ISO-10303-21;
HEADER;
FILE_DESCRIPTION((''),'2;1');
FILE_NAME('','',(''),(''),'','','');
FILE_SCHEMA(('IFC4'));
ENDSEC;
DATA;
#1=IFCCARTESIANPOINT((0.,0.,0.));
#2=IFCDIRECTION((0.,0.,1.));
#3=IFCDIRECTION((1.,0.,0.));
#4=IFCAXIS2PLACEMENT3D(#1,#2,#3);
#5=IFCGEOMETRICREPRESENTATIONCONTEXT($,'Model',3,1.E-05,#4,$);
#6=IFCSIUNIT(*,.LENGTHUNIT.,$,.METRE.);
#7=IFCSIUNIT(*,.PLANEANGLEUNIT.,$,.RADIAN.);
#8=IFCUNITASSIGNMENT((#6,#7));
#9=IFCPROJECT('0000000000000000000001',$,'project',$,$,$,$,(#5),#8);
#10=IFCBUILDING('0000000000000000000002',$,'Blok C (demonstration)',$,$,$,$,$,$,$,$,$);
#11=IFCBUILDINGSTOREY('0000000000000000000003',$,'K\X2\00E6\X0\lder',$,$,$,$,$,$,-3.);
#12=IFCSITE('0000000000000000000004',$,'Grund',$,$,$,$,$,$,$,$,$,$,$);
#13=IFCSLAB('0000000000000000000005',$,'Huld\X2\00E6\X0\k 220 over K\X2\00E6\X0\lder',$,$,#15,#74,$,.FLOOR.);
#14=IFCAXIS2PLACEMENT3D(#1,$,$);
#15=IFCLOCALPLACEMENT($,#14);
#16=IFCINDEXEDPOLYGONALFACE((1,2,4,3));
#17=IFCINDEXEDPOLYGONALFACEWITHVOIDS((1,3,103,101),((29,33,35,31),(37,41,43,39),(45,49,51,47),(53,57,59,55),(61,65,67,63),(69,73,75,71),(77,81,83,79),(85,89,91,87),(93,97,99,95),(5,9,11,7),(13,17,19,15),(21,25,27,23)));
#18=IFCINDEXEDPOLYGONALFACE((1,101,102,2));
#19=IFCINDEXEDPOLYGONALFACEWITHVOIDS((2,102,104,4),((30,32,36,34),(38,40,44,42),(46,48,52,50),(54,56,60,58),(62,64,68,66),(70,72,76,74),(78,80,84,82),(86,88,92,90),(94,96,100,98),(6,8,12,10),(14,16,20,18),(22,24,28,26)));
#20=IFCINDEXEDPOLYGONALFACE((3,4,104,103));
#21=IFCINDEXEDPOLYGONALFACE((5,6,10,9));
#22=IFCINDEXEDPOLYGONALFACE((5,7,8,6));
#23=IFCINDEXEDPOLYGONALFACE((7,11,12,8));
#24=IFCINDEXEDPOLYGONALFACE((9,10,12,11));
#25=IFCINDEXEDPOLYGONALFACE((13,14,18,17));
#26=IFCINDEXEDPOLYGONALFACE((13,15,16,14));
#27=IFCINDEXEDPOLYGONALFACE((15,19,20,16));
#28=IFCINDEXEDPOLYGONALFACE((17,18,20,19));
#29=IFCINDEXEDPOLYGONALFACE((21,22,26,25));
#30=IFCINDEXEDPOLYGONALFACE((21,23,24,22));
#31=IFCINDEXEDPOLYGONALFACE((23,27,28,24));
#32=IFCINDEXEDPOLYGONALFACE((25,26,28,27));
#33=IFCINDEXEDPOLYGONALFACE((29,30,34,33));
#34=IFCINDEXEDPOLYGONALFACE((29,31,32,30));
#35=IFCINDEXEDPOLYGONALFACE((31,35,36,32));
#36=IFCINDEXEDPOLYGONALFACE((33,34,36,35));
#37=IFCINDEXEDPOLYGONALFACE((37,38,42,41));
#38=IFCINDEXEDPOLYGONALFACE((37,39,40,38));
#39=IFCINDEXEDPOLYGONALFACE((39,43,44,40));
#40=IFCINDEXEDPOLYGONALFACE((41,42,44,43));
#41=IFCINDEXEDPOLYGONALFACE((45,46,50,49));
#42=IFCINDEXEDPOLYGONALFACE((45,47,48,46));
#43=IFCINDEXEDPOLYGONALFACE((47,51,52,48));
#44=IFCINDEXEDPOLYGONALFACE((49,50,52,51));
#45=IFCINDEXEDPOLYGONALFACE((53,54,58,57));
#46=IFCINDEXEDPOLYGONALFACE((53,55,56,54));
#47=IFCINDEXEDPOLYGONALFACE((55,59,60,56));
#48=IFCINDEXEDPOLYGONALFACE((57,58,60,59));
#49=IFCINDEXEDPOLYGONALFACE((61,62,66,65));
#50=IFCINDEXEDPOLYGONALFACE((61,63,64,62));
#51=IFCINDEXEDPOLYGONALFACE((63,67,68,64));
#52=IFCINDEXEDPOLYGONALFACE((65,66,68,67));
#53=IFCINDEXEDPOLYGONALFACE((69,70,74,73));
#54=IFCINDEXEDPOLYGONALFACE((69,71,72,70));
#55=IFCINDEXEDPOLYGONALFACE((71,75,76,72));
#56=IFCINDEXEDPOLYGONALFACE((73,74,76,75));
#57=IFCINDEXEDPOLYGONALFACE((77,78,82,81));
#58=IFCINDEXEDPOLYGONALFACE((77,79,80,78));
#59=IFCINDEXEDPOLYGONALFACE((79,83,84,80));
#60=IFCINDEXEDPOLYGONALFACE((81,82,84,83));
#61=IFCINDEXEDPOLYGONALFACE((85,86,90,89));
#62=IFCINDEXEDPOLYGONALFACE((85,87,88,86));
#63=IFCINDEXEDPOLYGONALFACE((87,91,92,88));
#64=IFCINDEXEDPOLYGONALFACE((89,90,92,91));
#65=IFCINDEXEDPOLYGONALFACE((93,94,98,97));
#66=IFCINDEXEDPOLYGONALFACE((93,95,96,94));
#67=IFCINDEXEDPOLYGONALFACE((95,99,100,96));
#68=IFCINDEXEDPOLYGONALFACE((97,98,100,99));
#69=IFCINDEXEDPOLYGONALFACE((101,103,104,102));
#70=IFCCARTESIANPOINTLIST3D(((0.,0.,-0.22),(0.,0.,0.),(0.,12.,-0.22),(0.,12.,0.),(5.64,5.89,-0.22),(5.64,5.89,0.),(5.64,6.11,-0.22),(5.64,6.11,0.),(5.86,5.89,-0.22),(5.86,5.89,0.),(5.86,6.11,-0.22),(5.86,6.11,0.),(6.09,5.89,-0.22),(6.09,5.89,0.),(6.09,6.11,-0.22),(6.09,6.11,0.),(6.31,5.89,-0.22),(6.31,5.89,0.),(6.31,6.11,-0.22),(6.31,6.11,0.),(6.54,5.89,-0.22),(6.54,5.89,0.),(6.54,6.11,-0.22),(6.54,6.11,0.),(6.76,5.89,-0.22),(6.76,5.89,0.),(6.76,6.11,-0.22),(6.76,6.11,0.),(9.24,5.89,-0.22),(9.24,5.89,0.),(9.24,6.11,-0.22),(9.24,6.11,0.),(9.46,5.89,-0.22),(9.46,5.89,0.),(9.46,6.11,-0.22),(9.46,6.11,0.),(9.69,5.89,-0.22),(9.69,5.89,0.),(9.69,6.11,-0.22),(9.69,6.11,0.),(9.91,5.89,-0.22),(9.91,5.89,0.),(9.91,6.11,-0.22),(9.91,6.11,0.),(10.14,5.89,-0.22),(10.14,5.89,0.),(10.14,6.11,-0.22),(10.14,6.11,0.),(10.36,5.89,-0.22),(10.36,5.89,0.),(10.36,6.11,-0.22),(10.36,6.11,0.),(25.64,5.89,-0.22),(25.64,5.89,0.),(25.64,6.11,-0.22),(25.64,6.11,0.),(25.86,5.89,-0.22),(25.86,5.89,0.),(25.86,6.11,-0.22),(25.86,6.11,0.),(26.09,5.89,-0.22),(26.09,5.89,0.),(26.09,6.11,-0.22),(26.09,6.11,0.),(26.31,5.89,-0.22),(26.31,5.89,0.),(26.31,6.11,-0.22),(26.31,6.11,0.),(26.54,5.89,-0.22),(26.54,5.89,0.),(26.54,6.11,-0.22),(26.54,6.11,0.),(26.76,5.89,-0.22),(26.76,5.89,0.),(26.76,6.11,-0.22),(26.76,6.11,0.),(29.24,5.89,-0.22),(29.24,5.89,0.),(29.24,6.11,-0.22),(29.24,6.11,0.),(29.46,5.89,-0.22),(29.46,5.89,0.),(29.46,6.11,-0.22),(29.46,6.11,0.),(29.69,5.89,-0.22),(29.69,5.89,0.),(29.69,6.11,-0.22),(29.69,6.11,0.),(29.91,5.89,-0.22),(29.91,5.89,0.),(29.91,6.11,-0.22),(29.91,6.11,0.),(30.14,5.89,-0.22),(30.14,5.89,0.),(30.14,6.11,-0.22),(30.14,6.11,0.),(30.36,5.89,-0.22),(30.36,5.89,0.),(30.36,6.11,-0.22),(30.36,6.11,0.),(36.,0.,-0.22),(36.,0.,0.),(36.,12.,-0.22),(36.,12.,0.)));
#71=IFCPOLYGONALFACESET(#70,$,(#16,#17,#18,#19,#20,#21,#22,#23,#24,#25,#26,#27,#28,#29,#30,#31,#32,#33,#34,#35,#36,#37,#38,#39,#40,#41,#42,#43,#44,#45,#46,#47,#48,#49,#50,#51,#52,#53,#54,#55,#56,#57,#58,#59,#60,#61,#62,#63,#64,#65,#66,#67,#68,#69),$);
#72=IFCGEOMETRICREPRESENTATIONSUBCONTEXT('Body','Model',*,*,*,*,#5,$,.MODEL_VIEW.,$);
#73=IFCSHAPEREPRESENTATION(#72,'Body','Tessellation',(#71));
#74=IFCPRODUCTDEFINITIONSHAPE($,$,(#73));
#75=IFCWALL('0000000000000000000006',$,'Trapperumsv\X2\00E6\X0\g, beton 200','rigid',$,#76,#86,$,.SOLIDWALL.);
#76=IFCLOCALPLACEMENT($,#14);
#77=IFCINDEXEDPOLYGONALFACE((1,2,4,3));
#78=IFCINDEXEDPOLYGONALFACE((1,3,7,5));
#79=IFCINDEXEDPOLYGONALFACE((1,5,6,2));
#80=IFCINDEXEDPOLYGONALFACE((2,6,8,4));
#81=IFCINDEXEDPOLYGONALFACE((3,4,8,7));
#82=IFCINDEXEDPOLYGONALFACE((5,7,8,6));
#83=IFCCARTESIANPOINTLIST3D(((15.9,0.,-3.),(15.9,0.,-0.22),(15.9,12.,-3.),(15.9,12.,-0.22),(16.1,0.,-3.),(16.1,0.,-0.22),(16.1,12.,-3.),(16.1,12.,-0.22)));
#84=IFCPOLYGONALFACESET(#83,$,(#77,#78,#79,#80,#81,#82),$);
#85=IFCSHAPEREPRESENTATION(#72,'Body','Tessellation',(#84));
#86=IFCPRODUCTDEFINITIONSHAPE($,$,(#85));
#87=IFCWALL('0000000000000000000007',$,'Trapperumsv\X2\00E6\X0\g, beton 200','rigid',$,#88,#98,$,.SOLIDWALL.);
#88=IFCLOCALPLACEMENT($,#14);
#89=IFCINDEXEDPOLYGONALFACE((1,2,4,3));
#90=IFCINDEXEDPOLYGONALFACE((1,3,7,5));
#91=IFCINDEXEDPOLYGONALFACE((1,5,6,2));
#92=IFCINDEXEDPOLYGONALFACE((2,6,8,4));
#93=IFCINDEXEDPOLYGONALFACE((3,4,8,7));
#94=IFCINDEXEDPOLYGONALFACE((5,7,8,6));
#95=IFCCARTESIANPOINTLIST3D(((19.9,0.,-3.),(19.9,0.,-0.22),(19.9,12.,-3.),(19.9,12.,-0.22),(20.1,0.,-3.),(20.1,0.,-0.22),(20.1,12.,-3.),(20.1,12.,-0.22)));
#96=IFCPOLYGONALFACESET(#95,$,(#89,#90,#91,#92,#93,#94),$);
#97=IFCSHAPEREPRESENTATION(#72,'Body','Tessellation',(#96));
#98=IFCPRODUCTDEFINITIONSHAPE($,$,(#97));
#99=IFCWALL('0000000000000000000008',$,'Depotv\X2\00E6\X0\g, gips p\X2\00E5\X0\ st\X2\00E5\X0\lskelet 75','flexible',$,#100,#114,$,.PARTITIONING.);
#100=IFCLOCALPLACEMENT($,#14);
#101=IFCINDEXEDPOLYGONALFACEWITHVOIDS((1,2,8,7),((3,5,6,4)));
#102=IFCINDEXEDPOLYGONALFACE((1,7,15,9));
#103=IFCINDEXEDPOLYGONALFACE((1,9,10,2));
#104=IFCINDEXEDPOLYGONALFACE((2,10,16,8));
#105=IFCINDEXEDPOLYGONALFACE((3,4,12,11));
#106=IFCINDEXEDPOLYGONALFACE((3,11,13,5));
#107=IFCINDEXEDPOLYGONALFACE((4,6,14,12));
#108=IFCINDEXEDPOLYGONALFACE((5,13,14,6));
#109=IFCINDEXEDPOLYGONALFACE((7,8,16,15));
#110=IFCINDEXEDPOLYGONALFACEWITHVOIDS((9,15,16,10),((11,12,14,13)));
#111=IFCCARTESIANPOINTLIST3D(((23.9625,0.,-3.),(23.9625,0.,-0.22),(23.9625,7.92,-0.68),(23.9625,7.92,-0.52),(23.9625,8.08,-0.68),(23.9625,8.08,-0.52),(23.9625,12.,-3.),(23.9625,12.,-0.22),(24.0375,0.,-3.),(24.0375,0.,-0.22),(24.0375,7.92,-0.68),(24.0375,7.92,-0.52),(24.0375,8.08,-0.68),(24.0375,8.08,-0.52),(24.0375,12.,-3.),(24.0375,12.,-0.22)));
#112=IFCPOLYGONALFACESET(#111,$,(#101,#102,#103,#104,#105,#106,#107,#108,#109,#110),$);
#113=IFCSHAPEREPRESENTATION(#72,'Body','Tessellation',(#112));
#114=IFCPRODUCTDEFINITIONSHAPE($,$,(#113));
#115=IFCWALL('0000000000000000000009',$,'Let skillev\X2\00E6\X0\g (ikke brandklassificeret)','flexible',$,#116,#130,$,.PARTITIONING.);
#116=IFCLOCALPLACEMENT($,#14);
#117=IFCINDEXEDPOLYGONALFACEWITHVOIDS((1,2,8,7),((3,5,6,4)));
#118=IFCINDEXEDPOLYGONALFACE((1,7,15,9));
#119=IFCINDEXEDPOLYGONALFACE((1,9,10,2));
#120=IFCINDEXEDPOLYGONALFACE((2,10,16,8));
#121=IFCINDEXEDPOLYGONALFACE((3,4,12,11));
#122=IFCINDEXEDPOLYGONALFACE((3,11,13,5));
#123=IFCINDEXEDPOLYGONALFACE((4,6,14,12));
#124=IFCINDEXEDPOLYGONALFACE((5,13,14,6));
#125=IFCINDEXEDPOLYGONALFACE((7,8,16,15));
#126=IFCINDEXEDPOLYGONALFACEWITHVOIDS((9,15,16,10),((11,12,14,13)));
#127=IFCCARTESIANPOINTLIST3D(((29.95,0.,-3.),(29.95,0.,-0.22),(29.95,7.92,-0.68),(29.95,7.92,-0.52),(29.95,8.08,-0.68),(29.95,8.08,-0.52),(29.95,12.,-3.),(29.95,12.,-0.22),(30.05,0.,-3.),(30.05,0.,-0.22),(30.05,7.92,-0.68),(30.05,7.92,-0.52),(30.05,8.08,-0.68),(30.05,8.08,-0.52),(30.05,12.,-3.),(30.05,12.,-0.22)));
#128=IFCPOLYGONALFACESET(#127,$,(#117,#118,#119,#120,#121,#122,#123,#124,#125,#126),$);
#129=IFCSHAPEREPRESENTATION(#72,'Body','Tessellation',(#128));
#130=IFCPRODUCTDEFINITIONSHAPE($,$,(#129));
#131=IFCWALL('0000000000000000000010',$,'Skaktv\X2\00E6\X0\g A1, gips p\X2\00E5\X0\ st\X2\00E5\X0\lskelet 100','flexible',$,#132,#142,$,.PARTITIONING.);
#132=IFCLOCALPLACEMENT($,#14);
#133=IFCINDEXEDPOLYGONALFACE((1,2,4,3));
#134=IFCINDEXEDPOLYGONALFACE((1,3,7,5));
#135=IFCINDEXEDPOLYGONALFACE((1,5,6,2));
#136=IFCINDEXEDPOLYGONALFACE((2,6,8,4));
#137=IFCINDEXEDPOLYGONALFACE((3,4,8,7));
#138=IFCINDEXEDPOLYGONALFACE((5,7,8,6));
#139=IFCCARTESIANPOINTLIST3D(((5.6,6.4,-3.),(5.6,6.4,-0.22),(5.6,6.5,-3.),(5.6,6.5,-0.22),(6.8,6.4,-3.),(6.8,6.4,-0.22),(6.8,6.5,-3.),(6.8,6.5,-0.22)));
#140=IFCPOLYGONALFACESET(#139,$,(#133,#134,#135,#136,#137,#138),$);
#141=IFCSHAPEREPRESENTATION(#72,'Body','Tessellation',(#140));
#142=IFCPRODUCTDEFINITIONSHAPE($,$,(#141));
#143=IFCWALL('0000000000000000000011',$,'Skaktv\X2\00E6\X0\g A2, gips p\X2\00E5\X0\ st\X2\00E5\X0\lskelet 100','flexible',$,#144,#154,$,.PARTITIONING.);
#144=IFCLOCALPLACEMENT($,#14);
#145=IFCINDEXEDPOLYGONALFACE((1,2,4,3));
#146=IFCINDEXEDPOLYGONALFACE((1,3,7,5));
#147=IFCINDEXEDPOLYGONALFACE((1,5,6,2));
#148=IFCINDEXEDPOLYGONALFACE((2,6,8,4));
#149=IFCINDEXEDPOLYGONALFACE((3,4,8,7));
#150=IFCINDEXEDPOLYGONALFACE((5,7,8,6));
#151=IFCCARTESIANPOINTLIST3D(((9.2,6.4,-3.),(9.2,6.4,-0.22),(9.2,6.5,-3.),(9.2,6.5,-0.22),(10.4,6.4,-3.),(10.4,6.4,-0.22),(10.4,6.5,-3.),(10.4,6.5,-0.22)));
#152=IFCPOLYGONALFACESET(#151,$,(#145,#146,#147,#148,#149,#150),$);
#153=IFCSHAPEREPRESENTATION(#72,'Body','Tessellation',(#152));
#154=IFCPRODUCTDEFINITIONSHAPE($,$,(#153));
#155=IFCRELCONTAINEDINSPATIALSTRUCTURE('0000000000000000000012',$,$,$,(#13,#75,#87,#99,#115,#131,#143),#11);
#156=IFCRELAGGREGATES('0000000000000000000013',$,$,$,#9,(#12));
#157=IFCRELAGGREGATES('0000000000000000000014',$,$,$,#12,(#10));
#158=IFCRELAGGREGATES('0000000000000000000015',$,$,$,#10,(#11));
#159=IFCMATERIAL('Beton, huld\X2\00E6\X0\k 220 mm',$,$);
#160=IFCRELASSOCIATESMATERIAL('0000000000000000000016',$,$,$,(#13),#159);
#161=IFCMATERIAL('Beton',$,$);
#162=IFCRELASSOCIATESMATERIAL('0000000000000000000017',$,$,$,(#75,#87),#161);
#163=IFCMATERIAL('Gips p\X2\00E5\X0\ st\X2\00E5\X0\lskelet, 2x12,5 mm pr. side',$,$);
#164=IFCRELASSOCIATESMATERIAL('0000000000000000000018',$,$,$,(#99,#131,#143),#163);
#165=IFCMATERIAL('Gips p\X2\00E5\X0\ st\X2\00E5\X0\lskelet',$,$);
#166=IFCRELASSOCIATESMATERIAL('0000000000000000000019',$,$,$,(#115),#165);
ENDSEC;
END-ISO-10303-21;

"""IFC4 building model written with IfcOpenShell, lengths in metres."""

from ifc_helpers import new_model, si_unit, frame, origin_with_axes, place, context, subcontext, project, spatial, polyline, outline, extrude, material, element, save


model = new_model("IFC4")

# Units and contexts
model_context = context("Model", 3, precision=1e-05, world=origin_with_axes())
body_context = subcontext(model_context, "Body", "Model", "MODEL_VIEW")
ifc_project = project(units=[si_unit("LENGTHUNIT", "METRE"), si_unit("PLANEANGLEUNIT", "RADIAN")], contexts=[model_context])

# Site, building, storey
site = spatial("IfcSite", under=ifc_project, Name="Grund")
building = spatial("IfcBuilding", under=site, Name="Blok C (demonstration)")
storey = spatial("IfcBuildingStorey", under=building, Name="Kælder", Elevation=-3.0)

# Slab, openings
ifc_material_1 = material(Name="Beton, huldæk 220 mm")
slab_placement = place(None, origin_with_axes())
slab = element("IfcSlab", 1, at=slab_placement, inside=storey, material=ifc_material_1, Name="Huldæk 220 over Kælder", PredefinedType="FLOOR", context=body_context, shape_type="SweptSolid", body=[
    extrude(outline(polyline([(0.0, 0.0), (36.0, 0.0), (36.0, 12.0), (0.0, 12.0), (0.0, 0.0)])), frame((0.0, 0.0, -0.22)), (0.0, 0.0, 1.0), 0.22),
])
opening_1_placement = place(slab_placement, origin_with_axes())
element("IfcOpeningElement", 2, at=opening_1_placement, cuts=slab, PredefinedType="OPENING", context=body_context, shape_type="SweptSolid", body=[
    extrude(outline(polyline([(5.64, 5.89), (5.86, 5.89), (5.86, 6.11), (5.64, 6.11), (5.64, 5.89)])), frame((0.0, 0.0, -0.23)), (0.0, 0.0, 1.0), 0.24),
])
opening_2_placement = place(slab_placement, origin_with_axes())
element("IfcOpeningElement", 3, at=opening_2_placement, cuts=slab, PredefinedType="OPENING", context=body_context, shape_type="SweptSolid", body=[
    extrude(outline(polyline([(6.09, 5.89), (6.31, 5.89), (6.31, 6.11), (6.09, 6.11), (6.09, 5.89)])), frame((0.0, 0.0, -0.23)), (0.0, 0.0, 1.0), 0.24),
])
opening_3_placement = place(slab_placement, origin_with_axes())
element("IfcOpeningElement", 4, at=opening_3_placement, cuts=slab, PredefinedType="OPENING", context=body_context, shape_type="SweptSolid", body=[
    extrude(outline(polyline([(6.54, 5.89), (6.76, 5.89), (6.76, 6.11), (6.54, 6.11), (6.54, 5.89)])), frame((0.0, 0.0, -0.23)), (0.0, 0.0, 1.0), 0.24),
])
opening_4_placement = place(slab_placement, origin_with_axes())
element("IfcOpeningElement", 5, at=opening_4_placement, cuts=slab, PredefinedType="OPENING", context=body_context, shape_type="SweptSolid", body=[
    extrude(outline(polyline([(9.24, 5.89), (9.46, 5.89), (9.46, 6.11), (9.24, 6.11), (9.24, 5.89)])), frame((0.0, 0.0, -0.23)), (0.0, 0.0, 1.0), 0.24),
])
opening_5_placement = place(slab_placement, origin_with_axes())
element("IfcOpeningElement", 6, at=opening_5_placement, cuts=slab, PredefinedType="OPENING", context=body_context, shape_type="SweptSolid", body=[
    extrude(outline(polyline([(9.69, 5.89), (9.91, 5.89), (9.91, 6.11), (9.69, 6.11), (9.69, 5.89)])), frame((0.0, 0.0, -0.23)), (0.0, 0.0, 1.0), 0.24),
])
opening_6_placement = place(slab_placement, origin_with_axes())
element("IfcOpeningElement", 7, at=opening_6_placement, cuts=slab, PredefinedType="OPENING", context=body_context, shape_type="SweptSolid", body=[
    extrude(outline(polyline([(10.14, 5.89), (10.36, 5.89), (10.36, 6.11), (10.14, 6.11), (10.14, 5.89)])), frame((0.0, 0.0, -0.23)), (0.0, 0.0, 1.0), 0.24),
])
opening_7_placement = place(slab_placement, origin_with_axes())
element("IfcOpeningElement", 8, at=opening_7_placement, cuts=slab, PredefinedType="OPENING", context=body_context, shape_type="SweptSolid", body=[
    extrude(outline(polyline([(25.64, 5.89), (25.86, 5.89), (25.86, 6.11), (25.64, 6.11), (25.64, 5.89)])), frame((0.0, 0.0, -0.23)), (0.0, 0.0, 1.0), 0.24),
])
opening_8_placement = place(slab_placement, origin_with_axes())
element("IfcOpeningElement", 9, at=opening_8_placement, cuts=slab, PredefinedType="OPENING", context=body_context, shape_type="SweptSolid", body=[
    extrude(outline(polyline([(26.09, 5.89), (26.31, 5.89), (26.31, 6.11), (26.09, 6.11), (26.09, 5.89)])), frame((0.0, 0.0, -0.23)), (0.0, 0.0, 1.0), 0.24),
])
opening_9_placement = place(slab_placement, origin_with_axes())
element("IfcOpeningElement", 10, at=opening_9_placement, cuts=slab, PredefinedType="OPENING", context=body_context, shape_type="SweptSolid", body=[
    extrude(outline(polyline([(26.54, 5.89), (26.76, 5.89), (26.76, 6.11), (26.54, 6.11), (26.54, 5.89)])), frame((0.0, 0.0, -0.23)), (0.0, 0.0, 1.0), 0.24),
])
opening_10_placement = place(slab_placement, origin_with_axes())
element("IfcOpeningElement", 11, at=opening_10_placement, cuts=slab, PredefinedType="OPENING", context=body_context, shape_type="SweptSolid", body=[
    extrude(outline(polyline([(29.24, 5.89), (29.46, 5.89), (29.46, 6.11), (29.24, 6.11), (29.24, 5.89)])), frame((0.0, 0.0, -0.23)), (0.0, 0.0, 1.0), 0.24),
])
opening_11_placement = place(slab_placement, origin_with_axes())
element("IfcOpeningElement", 12, at=opening_11_placement, cuts=slab, PredefinedType="OPENING", context=body_context, shape_type="SweptSolid", body=[
    extrude(outline(polyline([(29.69, 5.89), (29.91, 5.89), (29.91, 6.11), (29.69, 6.11), (29.69, 5.89)])), frame((0.0, 0.0, -0.23)), (0.0, 0.0, 1.0), 0.24),
])
opening_12_placement = place(slab_placement, origin_with_axes())
element("IfcOpeningElement", 13, at=opening_12_placement, cuts=slab, PredefinedType="OPENING", context=body_context, shape_type="SweptSolid", body=[
    extrude(outline(polyline([(30.14, 5.89), (30.36, 5.89), (30.36, 6.11), (30.14, 6.11), (30.14, 5.89)])), frame((0.0, 0.0, -0.23)), (0.0, 0.0, 1.0), 0.24),
])

# Walls
ifc_material_2 = material(Name="Beton")
wall_1_placement = place(None, origin_with_axes())
element("IfcWall", 14, at=wall_1_placement, inside=storey, material=ifc_material_2, Name="Trapperumsvæg, beton 200", Description="rigid", PredefinedType="SOLIDWALL", context=body_context, shape_type="SweptSolid", body=[
    extrude(outline(polyline([(15.9, 0.0), (16.1, 0.0), (16.1, 12.0), (15.9, 12.0), (15.9, 0.0)])), frame((0.0, 0.0, -3.0)), (0.0, 0.0, 1.0), 2.78),
])
wall_2_placement = place(None, origin_with_axes())
element("IfcWall", 15, at=wall_2_placement, inside=storey, material=ifc_material_2, Name="Trapperumsvæg, beton 200", Description="rigid", PredefinedType="SOLIDWALL", context=body_context, shape_type="SweptSolid", body=[
    extrude(outline(polyline([(19.9, 0.0), (20.1, 0.0), (20.1, 12.0), (19.9, 12.0), (19.9, 0.0)])), frame((0.0, 0.0, -3.0)), (0.0, 0.0, 1.0), 2.78),
])

# Walls, openings
ifc_material_3 = material(Name="Gips på stålskelet, 2x12,5 mm pr. side")
wall_3_placement = place(None, origin_with_axes())
wall_3 = element("IfcWall", 16, at=wall_3_placement, inside=storey, material=ifc_material_3, Name="Depotvæg, gips på stålskelet 75", Description="flexible", PredefinedType="PARTITIONING", context=body_context, shape_type="SweptSolid", body=[
    extrude(outline(polyline([(23.9625, 0.0), (24.0375, 0.0), (24.0375, 12.0), (23.9625, 12.0), (23.9625, 0.0)])), frame((0.0, 0.0, -3.0)), (0.0, 0.0, 1.0), 2.78),
])
opening_13_placement = place(wall_3_placement, origin_with_axes())
element("IfcOpeningElement", 17, at=opening_13_placement, cuts=wall_3, PredefinedType="OPENING", context=body_context, shape_type="SweptSolid", body=[
    extrude(outline(polyline([(23.88, 7.92), (24.12, 7.92), (24.12, 8.08), (23.88, 8.08), (23.88, 7.92)])), frame((0.0, 0.0, -0.68)), (0.0, 0.0, 1.0), 0.16),
])
ifc_material_4 = material(Name="Gips på stålskelet")
wall_4_placement = place(None, origin_with_axes())
wall_4 = element("IfcWall", 18, at=wall_4_placement, inside=storey, material=ifc_material_4, Name="Let skillevæg (ikke brandklassificeret)", Description="flexible", PredefinedType="PARTITIONING", context=body_context, shape_type="SweptSolid", body=[
    extrude(outline(polyline([(29.95, 0.0), (30.05, 0.0), (30.05, 12.0), (29.95, 12.0), (29.95, 0.0)])), frame((0.0, 0.0, -3.0)), (0.0, 0.0, 1.0), 2.78),
])
opening_14_placement = place(wall_4_placement, origin_with_axes())
element("IfcOpeningElement", 19, at=opening_14_placement, cuts=wall_4, PredefinedType="OPENING", context=body_context, shape_type="SweptSolid", body=[
    extrude(outline(polyline([(29.88, 7.92), (30.12, 7.92), (30.12, 8.08), (29.88, 8.08), (29.88, 7.92)])), frame((0.0, 0.0, -0.68)), (0.0, 0.0, 1.0), 0.16),
])

# Walls
wall_5_placement = place(None, origin_with_axes())
element("IfcWall", 20, at=wall_5_placement, inside=storey, material=ifc_material_3, Name="Skaktvæg A1, gips på stålskelet 100", Description="flexible", PredefinedType="PARTITIONING", context=body_context, shape_type="SweptSolid", body=[
    extrude(outline(polyline([(5.6, 6.4), (6.8, 6.4), (6.8, 6.5), (5.6, 6.5), (5.6, 6.4)])), frame((0.0, 0.0, -3.0)), (0.0, 0.0, 1.0), 2.78),
])
wall_6_placement = place(None, origin_with_axes())
element("IfcWall", 21, at=wall_6_placement, inside=storey, material=ifc_material_3, Name="Skaktvæg A2, gips på stålskelet 100", Description="flexible", PredefinedType="PARTITIONING", context=body_context, shape_type="SweptSolid", body=[
    extrude(outline(polyline([(9.2, 6.4), (10.4, 6.4), (10.4, 6.5), (9.2, 6.5), (9.2, 6.4)])), frame((0.0, 0.0, -3.0)), (0.0, 0.0, 1.0), 2.78),
])

save(model, "model.ifc")
